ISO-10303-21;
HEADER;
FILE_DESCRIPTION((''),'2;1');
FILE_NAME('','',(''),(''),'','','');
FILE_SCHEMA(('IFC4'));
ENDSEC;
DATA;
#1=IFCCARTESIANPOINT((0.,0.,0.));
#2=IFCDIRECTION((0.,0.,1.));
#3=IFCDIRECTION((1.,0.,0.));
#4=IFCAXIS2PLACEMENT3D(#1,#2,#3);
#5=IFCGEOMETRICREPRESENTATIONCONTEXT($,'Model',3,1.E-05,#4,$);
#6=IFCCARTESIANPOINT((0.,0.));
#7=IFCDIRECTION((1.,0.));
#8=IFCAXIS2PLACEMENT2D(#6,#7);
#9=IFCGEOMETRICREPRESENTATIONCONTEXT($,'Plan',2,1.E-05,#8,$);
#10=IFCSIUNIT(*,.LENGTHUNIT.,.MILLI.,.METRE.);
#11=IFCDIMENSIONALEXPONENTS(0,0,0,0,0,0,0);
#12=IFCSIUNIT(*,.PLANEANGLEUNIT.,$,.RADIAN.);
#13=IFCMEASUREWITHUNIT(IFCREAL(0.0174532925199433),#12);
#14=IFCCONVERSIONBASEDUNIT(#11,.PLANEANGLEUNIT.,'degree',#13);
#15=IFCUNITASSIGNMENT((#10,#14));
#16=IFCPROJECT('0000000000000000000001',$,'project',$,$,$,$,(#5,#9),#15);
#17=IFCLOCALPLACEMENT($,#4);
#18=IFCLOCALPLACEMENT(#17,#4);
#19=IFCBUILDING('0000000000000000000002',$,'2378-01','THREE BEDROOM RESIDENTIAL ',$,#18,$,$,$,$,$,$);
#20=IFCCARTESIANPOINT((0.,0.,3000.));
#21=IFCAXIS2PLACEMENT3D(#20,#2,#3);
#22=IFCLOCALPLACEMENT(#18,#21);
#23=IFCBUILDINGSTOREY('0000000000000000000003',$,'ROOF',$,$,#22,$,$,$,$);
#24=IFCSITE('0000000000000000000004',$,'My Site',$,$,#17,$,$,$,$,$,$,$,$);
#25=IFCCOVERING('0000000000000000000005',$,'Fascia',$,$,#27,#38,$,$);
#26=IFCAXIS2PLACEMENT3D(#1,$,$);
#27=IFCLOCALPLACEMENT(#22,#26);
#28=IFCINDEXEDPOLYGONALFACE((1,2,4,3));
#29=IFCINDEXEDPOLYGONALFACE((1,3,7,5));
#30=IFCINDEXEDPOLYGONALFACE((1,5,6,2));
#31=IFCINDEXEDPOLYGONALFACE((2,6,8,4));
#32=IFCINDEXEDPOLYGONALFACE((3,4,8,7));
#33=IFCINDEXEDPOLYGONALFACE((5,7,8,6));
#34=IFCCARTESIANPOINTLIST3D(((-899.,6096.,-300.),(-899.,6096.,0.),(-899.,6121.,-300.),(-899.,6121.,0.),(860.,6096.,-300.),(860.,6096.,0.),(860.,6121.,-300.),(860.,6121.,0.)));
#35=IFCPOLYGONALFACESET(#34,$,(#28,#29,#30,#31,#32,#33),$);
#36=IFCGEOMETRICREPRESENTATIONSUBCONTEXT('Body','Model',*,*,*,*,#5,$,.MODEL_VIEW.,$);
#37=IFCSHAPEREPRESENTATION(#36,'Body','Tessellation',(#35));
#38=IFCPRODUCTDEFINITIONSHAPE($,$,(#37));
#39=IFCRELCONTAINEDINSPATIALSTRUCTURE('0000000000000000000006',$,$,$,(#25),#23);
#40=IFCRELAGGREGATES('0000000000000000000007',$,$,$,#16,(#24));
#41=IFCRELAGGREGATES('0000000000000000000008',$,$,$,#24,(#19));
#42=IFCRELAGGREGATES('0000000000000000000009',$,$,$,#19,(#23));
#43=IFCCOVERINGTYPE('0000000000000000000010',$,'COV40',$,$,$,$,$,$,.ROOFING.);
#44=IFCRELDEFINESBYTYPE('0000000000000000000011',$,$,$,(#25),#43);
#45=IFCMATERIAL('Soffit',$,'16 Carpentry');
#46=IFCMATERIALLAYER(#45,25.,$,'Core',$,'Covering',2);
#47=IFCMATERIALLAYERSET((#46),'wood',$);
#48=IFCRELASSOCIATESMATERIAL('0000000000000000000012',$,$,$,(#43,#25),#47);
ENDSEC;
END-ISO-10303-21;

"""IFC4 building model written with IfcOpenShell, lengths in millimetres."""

from ifc_helpers import new_model, entity, si_unit, converted_unit, frame, origin_with_axes, origin_2d_with_axis, place, context, subcontext, project, spatial, indexed_curve, outline, extrude, material, layer, layer_set, layer_usage, type_object, element, save


model = new_model("IFC4")

# Units and contexts
model_context = context("Model", 3, precision=1e-05, world=origin_with_axes())
plan_context = context("Plan", 2, precision=1e-05, world=origin_2d_with_axis())
body_context = subcontext(model_context, "Body", "Model", "MODEL_VIEW")
ifc_project = project(units=[si_unit("LENGTHUNIT", "METRE", prefix="MILLI"), converted_unit("PLANEANGLEUNIT", "degree", entity("IfcReal", 0.0174532925199433), si_unit("PLANEANGLEUNIT", "RADIAN"), dimensions=[0, 0, 0, 0, 0, 0, 0])], contexts=[model_context, plan_context])

# Site, building, storey
site_placement = place(None, origin_with_axes())
site = spatial("IfcSite", under=ifc_project, at=site_placement, Name="My Site")
building_placement = place(site_placement, origin_with_axes())
building = spatial("IfcBuilding", under=site, at=building_placement, Name="2378-01", Description="THREE BEDROOM RESIDENTIAL ")
storey_placement = place(building_placement, frame((0.0, 0.0, 3000.0), z_axis=(0.0, 0.0, 1.0), x_axis=(1.0, 0.0, 0.0)))
storey = spatial("IfcBuildingStorey", under=building, at=storey_placement, Name="ROOF")

# Covering
ifc_material_1 = material(Name="Soffit", Category="16 Carpentry")
ifc_layer = layer(ifc_material_1, 25.0, Name="Core", Category="Covering", Priority=2)
ifc_layer_set = layer_set([ifc_layer], Name="wood")
covering_type = type_object("IfcCoveringType", Name="COV40", PredefinedType="ROOFING", material=ifc_layer_set)
ifc_layer_usage_1 = layer_usage(ifc_layer_set, "AXIS2", "POSITIVE", 0.0)
covering_1_placement = place(storey_placement, frame((-899.0, 6096.0, -300.0), z_axis=(0.0, 0.0, 1.0), x_axis=(1.0, 0.0, 0.0)))
element("IfcCovering", 1, at=covering_1_placement, inside=storey, type_object=covering_type, material=ifc_layer_usage_1, Name="Fascia", context=body_context, shape_type="SweptSolid", body=[
    extrude(outline(indexed_curve([(0.0, 0.0), (0.0, 25.0), (1759.0, 25.0), (1759.0, 0.0), (0.0, 0.0)], self_intersect=False)), origin_with_axes(), (0.0, 0.0, 1.0), 300.0),
])

save(model, "model.ifc")
